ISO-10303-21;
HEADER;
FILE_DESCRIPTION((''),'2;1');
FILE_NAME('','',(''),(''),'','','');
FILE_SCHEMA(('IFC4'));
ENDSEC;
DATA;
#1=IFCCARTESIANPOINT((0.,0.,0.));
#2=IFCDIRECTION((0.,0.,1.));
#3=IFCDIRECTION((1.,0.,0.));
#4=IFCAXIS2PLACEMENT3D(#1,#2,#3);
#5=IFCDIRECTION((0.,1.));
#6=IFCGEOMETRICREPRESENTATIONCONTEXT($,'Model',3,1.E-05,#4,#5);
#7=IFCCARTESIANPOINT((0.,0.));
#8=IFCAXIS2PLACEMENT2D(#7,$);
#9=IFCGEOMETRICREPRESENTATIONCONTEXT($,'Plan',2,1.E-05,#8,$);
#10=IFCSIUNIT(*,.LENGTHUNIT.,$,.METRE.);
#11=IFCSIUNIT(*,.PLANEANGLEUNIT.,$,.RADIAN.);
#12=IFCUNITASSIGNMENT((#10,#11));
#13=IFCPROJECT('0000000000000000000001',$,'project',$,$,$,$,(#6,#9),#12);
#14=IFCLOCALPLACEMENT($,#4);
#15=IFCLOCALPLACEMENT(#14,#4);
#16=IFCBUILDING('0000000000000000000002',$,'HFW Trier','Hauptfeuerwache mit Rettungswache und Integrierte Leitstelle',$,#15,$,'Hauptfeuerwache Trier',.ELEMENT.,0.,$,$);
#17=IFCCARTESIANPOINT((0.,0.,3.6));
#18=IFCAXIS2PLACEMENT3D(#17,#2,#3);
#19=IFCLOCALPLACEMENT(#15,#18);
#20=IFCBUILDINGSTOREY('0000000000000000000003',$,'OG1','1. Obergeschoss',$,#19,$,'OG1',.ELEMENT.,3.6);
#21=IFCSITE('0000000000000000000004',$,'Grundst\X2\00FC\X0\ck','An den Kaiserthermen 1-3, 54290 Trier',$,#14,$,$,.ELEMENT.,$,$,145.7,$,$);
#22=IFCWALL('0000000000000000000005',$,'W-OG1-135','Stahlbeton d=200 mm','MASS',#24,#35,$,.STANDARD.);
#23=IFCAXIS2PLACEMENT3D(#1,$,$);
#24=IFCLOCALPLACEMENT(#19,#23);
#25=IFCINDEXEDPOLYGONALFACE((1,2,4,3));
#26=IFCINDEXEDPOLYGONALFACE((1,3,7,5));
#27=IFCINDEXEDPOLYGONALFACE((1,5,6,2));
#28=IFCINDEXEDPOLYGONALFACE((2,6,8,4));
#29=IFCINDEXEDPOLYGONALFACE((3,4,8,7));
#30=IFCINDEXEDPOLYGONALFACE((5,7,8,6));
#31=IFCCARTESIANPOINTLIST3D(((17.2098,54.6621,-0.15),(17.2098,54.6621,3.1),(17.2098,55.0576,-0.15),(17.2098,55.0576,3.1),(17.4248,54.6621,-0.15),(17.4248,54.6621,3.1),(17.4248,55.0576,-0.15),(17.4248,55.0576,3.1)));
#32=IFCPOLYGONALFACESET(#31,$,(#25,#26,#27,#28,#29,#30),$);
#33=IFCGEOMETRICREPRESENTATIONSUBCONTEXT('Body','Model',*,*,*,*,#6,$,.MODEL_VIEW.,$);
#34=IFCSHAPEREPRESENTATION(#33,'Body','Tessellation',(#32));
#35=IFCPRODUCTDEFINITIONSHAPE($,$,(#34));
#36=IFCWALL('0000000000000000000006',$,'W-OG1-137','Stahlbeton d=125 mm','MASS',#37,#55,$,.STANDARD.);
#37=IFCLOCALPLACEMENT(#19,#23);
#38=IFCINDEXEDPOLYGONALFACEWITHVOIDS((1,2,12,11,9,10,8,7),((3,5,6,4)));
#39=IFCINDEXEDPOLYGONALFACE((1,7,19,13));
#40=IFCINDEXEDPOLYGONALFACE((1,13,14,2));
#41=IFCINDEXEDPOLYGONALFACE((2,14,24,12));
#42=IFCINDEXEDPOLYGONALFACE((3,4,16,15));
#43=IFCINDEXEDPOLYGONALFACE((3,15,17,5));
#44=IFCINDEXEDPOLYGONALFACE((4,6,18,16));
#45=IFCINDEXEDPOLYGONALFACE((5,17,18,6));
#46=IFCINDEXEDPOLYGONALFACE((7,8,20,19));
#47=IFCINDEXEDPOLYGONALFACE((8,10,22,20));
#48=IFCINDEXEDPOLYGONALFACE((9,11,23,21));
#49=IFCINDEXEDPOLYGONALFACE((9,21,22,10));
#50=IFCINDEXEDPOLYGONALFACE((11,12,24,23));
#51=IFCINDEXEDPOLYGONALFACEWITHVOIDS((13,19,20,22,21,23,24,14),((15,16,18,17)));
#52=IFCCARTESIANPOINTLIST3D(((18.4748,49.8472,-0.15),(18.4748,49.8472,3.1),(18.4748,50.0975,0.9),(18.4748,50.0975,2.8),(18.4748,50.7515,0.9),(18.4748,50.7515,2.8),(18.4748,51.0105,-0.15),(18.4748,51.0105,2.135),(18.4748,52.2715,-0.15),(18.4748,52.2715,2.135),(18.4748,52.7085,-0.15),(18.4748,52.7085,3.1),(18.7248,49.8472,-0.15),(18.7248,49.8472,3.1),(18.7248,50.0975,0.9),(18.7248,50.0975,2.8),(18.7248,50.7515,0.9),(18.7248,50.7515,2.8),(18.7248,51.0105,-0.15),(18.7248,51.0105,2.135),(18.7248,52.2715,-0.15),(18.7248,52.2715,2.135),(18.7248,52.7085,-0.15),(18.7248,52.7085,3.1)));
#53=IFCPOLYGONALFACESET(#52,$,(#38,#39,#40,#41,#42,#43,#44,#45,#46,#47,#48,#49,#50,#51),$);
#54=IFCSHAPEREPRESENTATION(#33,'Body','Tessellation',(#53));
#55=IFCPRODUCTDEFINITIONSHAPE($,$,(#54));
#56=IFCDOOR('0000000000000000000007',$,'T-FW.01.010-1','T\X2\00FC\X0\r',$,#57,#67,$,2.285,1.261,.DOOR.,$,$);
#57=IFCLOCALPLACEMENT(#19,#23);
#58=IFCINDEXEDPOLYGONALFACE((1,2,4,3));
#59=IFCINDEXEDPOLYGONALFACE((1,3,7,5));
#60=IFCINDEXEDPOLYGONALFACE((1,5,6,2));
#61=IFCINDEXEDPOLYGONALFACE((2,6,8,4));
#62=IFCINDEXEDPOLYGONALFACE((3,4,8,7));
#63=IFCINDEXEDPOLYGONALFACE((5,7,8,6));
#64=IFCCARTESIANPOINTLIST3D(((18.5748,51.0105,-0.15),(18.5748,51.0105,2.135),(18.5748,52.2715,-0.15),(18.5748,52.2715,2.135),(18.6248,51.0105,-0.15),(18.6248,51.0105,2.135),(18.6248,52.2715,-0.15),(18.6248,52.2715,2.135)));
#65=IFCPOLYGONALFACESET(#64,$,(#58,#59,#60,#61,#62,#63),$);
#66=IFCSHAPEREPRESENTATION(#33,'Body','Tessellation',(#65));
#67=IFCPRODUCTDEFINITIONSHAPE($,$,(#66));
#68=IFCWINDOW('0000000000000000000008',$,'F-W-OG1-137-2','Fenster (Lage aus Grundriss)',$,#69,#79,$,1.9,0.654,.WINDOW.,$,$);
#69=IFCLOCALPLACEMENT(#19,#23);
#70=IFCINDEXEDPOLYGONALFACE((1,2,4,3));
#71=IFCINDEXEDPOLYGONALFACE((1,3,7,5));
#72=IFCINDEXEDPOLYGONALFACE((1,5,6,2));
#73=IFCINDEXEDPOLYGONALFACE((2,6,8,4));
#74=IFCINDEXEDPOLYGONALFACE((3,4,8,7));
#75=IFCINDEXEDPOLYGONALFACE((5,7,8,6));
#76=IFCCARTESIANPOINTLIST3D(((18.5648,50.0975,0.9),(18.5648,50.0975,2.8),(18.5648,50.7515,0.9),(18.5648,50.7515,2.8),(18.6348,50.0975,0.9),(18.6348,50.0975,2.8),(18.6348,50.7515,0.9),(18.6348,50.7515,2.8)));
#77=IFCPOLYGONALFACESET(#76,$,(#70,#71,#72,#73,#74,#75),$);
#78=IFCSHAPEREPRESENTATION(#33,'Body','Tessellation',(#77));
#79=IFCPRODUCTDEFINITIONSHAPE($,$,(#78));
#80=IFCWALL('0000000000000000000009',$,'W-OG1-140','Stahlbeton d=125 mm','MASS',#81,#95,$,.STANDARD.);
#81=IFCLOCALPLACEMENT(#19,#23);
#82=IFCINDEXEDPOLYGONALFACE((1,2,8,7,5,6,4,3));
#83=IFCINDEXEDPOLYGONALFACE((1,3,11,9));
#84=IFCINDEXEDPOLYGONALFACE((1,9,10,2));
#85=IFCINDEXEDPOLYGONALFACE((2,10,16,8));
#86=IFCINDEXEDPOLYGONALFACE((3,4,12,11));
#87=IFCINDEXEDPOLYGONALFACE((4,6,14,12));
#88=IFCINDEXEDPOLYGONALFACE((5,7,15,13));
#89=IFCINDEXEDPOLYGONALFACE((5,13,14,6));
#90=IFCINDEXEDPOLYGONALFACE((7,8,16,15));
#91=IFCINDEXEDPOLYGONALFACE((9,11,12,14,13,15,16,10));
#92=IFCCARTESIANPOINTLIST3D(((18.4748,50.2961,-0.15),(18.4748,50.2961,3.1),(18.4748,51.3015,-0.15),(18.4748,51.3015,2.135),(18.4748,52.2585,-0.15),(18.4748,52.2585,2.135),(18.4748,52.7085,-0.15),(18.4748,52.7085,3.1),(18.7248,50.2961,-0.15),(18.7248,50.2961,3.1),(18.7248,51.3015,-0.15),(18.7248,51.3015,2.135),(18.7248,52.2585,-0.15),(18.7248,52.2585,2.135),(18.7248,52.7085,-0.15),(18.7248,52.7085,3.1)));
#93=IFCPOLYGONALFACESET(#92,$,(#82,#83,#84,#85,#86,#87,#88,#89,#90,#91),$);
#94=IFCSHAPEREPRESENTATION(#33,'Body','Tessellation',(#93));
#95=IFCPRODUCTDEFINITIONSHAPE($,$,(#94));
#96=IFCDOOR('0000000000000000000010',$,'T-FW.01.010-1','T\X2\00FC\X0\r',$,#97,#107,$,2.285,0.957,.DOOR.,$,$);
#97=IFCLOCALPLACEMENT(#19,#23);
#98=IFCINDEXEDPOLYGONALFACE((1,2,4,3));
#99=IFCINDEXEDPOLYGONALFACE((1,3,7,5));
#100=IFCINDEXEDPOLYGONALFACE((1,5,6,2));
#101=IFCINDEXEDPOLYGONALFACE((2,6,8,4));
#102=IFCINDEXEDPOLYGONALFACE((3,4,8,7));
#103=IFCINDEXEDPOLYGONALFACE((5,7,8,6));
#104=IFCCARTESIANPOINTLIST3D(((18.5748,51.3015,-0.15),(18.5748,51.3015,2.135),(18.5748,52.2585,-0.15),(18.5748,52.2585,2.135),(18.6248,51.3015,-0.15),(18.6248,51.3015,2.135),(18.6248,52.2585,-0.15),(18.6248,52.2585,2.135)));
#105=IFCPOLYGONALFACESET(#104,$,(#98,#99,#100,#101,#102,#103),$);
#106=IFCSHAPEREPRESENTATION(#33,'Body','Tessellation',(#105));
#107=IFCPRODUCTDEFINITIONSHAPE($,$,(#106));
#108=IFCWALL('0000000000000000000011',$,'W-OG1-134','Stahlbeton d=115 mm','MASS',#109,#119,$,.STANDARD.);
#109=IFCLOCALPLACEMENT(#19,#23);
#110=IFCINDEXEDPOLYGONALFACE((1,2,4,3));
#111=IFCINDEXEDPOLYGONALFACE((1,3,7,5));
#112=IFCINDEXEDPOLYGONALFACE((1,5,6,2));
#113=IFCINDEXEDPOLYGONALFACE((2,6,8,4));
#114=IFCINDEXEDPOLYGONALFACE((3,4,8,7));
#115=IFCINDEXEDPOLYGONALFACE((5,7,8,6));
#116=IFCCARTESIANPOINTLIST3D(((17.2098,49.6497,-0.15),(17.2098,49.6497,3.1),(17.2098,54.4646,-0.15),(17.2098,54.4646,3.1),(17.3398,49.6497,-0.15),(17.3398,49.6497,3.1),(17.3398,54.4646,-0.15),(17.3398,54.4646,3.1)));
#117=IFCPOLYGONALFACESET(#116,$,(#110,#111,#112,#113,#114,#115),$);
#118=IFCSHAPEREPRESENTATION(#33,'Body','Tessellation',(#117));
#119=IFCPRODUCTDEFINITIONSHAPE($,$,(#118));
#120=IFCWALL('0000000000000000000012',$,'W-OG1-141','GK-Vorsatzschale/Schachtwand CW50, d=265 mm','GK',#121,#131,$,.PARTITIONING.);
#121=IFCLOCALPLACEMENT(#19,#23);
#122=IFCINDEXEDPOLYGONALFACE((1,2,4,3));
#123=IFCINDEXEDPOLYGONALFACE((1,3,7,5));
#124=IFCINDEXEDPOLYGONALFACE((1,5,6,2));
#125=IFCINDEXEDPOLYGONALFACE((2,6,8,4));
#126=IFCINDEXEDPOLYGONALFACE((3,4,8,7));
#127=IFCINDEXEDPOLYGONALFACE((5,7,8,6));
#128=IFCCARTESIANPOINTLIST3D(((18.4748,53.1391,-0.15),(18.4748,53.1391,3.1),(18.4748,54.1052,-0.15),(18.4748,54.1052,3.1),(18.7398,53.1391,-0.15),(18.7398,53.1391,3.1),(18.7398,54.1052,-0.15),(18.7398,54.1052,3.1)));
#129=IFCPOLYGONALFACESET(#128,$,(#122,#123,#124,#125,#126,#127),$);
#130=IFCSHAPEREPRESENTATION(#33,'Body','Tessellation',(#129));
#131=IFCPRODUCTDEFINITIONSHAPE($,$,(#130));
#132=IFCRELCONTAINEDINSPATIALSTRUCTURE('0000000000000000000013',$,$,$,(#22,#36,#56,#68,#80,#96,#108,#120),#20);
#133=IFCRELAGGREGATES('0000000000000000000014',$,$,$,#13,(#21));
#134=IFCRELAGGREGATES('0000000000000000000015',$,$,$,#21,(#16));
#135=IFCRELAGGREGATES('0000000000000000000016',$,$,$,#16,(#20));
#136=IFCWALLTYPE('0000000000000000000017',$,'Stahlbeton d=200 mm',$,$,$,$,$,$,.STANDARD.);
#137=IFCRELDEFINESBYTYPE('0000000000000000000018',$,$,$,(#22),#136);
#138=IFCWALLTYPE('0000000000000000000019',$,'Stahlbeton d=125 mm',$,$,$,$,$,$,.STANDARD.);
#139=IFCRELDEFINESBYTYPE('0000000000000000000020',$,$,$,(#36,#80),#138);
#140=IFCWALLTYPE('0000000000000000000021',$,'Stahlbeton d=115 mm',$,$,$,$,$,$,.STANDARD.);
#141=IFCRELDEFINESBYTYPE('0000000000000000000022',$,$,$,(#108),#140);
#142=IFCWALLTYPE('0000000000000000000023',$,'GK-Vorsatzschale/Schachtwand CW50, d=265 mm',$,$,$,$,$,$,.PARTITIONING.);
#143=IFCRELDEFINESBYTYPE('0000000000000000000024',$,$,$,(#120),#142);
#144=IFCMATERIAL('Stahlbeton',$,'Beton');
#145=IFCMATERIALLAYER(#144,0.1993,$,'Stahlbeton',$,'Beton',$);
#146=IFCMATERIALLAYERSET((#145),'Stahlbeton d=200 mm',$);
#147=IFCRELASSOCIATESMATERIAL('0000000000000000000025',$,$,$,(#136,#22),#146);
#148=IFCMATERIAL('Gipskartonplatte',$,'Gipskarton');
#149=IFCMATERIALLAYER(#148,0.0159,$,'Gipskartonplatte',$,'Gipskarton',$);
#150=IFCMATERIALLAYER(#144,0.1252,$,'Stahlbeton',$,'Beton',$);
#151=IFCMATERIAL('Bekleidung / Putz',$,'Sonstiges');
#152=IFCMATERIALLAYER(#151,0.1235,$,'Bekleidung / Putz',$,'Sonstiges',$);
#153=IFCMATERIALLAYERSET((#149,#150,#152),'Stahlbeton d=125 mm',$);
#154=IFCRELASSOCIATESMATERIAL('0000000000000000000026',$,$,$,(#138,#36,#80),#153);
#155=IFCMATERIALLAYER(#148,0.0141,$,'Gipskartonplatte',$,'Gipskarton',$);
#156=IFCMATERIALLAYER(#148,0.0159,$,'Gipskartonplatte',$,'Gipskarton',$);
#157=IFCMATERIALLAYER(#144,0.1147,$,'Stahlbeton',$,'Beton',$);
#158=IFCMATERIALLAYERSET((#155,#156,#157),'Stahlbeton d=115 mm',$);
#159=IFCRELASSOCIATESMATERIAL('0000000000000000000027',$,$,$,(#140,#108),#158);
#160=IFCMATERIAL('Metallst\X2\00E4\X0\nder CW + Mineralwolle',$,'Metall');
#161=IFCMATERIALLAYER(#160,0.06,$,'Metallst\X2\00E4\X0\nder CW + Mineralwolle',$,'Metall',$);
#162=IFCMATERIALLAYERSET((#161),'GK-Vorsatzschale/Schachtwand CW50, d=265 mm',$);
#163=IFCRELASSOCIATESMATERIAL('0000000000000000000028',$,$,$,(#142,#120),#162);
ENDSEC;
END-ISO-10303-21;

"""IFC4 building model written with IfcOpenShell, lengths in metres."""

from ifc_helpers import new_model, si_unit, direction, frame, frame_2d, origin_with_axes, origin_2d, place, context, subcontext, project, spatial, rectangle, extrude, material, layer, layer_set, layer_usage, type_object, element, fill, save


model = new_model("IFC4")

# Units and contexts
model_context = context("Model", 3, precision=1e-05, world=origin_with_axes(), true_north=direction((0.0, 1.0)))
plan_context = context("Plan", 2, precision=1e-05, world=origin_2d())
body_context = subcontext(model_context, "Body", "Model", "MODEL_VIEW")
ifc_project = project(units=[si_unit("LENGTHUNIT", "METRE"), si_unit("PLANEANGLEUNIT", "RADIAN")], contexts=[model_context, plan_context])

# Site, building, storey
site_placement = place(None, origin_with_axes())
site = spatial("IfcSite", under=ifc_project, at=site_placement, Name="Grundstück", Description="An den Kaiserthermen 1-3, 54290 Trier", CompositionType="ELEMENT", RefElevation=145.7)
building_placement = place(site_placement, origin_with_axes())
building = spatial("IfcBuilding", under=site, at=building_placement, Name="HFW Trier", Description="Hauptfeuerwache mit Rettungswache und Integrierte Leitstelle", LongName="Hauptfeuerwache Trier", CompositionType="ELEMENT", ElevationOfRefHeight=0.0)
storey_placement = place(building_placement, frame((0.0, 0.0, 3.6), z_axis=(0.0, 0.0, 1.0), x_axis=(1.0, 0.0, 0.0)))
storey = spatial("IfcBuildingStorey", under=building, at=storey_placement, Name="OG1", Description="1. Obergeschoss", LongName="OG1", CompositionType="ELEMENT", Elevation=3.6)

# Shared definitions
ifc_material_1 = material(Name="Gipskartonplatte", Category="Gipskarton")
ifc_material_2 = material(Name="Metallständer CW + Mineralwolle", Category="Metall")

# Wall
ifc_material_3 = material(Name="Stahlbeton", Category="Beton")
ifc_layer_1 = layer(ifc_material_3, 0.1993, Name="Stahlbeton", Category="Beton")
ifc_layer_set_1 = layer_set([ifc_layer_1], Name="Stahlbeton d=200 mm")
ifc_layer_usage_1 = layer_usage(ifc_layer_set_1, "AXIS2", "POSITIVE", -0.1075)
wall_type_1 = type_object("IfcWallType", Name="Stahlbeton d=200 mm", PredefinedType="STANDARD", material=ifc_layer_set_1)
wall_1_placement = place(storey_placement, frame((17.3173, 55.0576, -0.15), z_axis=(0.0, 0.0, 1.0), x_axis=(0.0, -1.0, 0.0)))
element("IfcWall", 1, at=wall_1_placement, inside=storey, type_object=wall_type_1, material=ifc_layer_usage_1, Name="W-OG1-135", Description="Stahlbeton d=200 mm", ObjectType="MASS", PredefinedType="STANDARD", context=body_context, shape_type="SweptSolid", body=[
    extrude(rectangle(XDim=0.3955, YDim=0.215, at=frame_2d((0.1977, 0.0))), origin_with_axes(), (0.0, 0.0, 1.0), 3.25),
])

# Wall, openings, door, window
ifc_layer_2 = layer(ifc_material_1, 0.0159, Name="Gipskartonplatte", Category="Gipskarton")
ifc_layer_3 = layer(ifc_material_3, 0.1252, Name="Stahlbeton", Category="Beton")
ifc_material_4 = material(Name="Bekleidung / Putz", Category="Sonstiges")
ifc_layer_4 = layer(ifc_material_4, 0.1235, Name="Bekleidung / Putz", Category="Sonstiges")
ifc_layer_set_2 = layer_set([ifc_layer_2, ifc_layer_3, ifc_layer_4], Name="Stahlbeton d=125 mm")
ifc_layer_usage_2 = layer_usage(ifc_layer_set_2, "AXIS2", "POSITIVE", -0.125)
wall_type_2 = type_object("IfcWallType", Name="Stahlbeton d=125 mm", PredefinedType="STANDARD", material=ifc_layer_set_2)
wall_2_placement = place(storey_placement, frame((18.5998, 52.7085, -0.15), z_axis=(0.0, 0.0, 1.0), x_axis=(0.0, -1.0, 0.0)))
wall_2 = element("IfcWall", 2, at=wall_2_placement, inside=storey, type_object=wall_type_2, material=ifc_layer_usage_2, Name="W-OG1-137", Description="Stahlbeton d=125 mm", ObjectType="MASS", PredefinedType="STANDARD", context=body_context, shape_type="SweptSolid", body=[
    extrude(rectangle(XDim=2.8613, YDim=0.25, at=frame_2d((1.4306, 0.0))), origin_with_axes(), (0.0, 0.0, 1.0), 3.25),
])
opening_1_placement = place(wall_2_placement, frame((0.437, 0.0, 0.0), z_axis=(0.0, 0.0, 1.0), x_axis=(1.0, 0.0, 0.0)))
opening_1 = element("IfcOpeningElement", 3, at=opening_1_placement, cuts=wall_2, PredefinedType="OPENING", context=body_context, shape_type="SweptSolid", body=[
    extrude(rectangle(XDim=1.261, YDim=0.35, at=frame_2d((0.6305, 0.0))), origin_with_axes(), (0.0, 0.0, 1.0), 2.285),
])
opening_2_placement = place(wall_2_placement, frame((1.957, 0.0, 0.0), z_axis=(0.0, 0.0, 1.0), x_axis=(1.0, 0.0, 0.0)))
opening_2 = element("IfcOpeningElement", 4, at=opening_2_placement, cuts=wall_2, PredefinedType="OPENING", context=body_context, shape_type="SweptSolid", body=[
    extrude(rectangle(XDim=0.654, YDim=0.35, at=frame_2d((0.327, 0.0))), frame((0.0, 0.0, 1.05), z_axis=(0.0, 0.0, 1.0), x_axis=(1.0, 0.0, 0.0)), (0.0, 0.0, 1.0), 1.9),
])
door_1_placement = place(wall_2_placement, frame((0.437, 0.0, 0.0), z_axis=(0.0, 0.0, 1.0), x_axis=(1.0, 0.0, 0.0)))
door_1 = element("IfcDoor", 5, at=door_1_placement, inside=storey, Name="T-FW.01.010-1", Description="Tür", OverallHeight=2.285, OverallWidth=1.261, PredefinedType="DOOR", context=body_context, shape_type="SweptSolid", body=[
    extrude(rectangle(XDim=1.261, YDim=0.05, at=frame_2d((0.6305, 0.0))), origin_with_axes(), (0.0, 0.0, 1.0), 2.285),
])
fill(opening_1, door_1)
window_placement = place(wall_2_placement, frame((1.957, 0.0, 0.0), z_axis=(0.0, 0.0, 1.0), x_axis=(1.0, 0.0, 0.0)))
window = element("IfcWindow", 6, at=window_placement, inside=storey, Name="F-W-OG1-137-2", Description="Fenster (Lage aus Grundriss)", OverallHeight=1.9, OverallWidth=0.654, PredefinedType="WINDOW", context=body_context, shape_type="SweptSolid", body=[
    extrude(rectangle(XDim=0.654, YDim=0.07, at=frame_2d((0.327, 0.0))), frame((0.0, 0.0, 1.05), z_axis=(0.0, 0.0, 1.0), x_axis=(1.0, 0.0, 0.0)), (0.0, 0.0, 1.0), 1.9),
])
fill(opening_2, window)

# Wall, opening, door
ifc_layer_usage_3 = layer_usage(ifc_layer_set_2, "AXIS2", "POSITIVE", -0.125)
wall_3_placement = place(storey_placement, frame((18.5998, 52.7085, -0.15), z_axis=(0.0, 0.0, 1.0), x_axis=(0.0, -1.0, 0.0)))
wall_3 = element("IfcWall", 7, at=wall_3_placement, inside=storey, type_object=wall_type_2, material=ifc_layer_usage_3, Name="W-OG1-140", Description="Stahlbeton d=125 mm", ObjectType="MASS", PredefinedType="STANDARD", context=body_context, shape_type="SweptSolid", body=[
    extrude(rectangle(XDim=2.4124, YDim=0.25, at=frame_2d((1.2062, 0.0))), origin_with_axes(), (0.0, 0.0, 1.0), 3.25),
])
opening_3_placement = place(wall_3_placement, frame((0.45, 0.0, 0.0), z_axis=(0.0, 0.0, 1.0), x_axis=(1.0, 0.0, 0.0)))
opening_3 = element("IfcOpeningElement", 8, at=opening_3_placement, cuts=wall_3, PredefinedType="OPENING", context=body_context, shape_type="SweptSolid", body=[
    extrude(rectangle(XDim=0.957, YDim=0.35, at=frame_2d((0.4785, 0.0))), origin_with_axes(), (0.0, 0.0, 1.0), 2.285),
])
door_2_placement = place(wall_3_placement, frame((0.45, 0.0, 0.0), z_axis=(0.0, 0.0, 1.0), x_axis=(1.0, 0.0, 0.0)))
door_2 = element("IfcDoor", 9, at=door_2_placement, inside=storey, Name="T-FW.01.010-1", Description="Tür", OverallHeight=2.285, OverallWidth=0.957, PredefinedType="DOOR", context=body_context, shape_type="SweptSolid", body=[
    extrude(rectangle(XDim=0.957, YDim=0.05, at=frame_2d((0.4785, 0.0))), origin_with_axes(), (0.0, 0.0, 1.0), 2.285),
])
fill(opening_3, door_2)

# Walls
ifc_layer_5 = layer(ifc_material_1, 0.0141, Name="Gipskartonplatte", Category="Gipskarton")
ifc_layer_6 = layer(ifc_material_1, 0.0159, Name="Gipskartonplatte", Category="Gipskarton")
ifc_layer_7 = layer(ifc_material_3, 0.1147, Name="Stahlbeton", Category="Beton")
ifc_layer_set_3 = layer_set([ifc_layer_5, ifc_layer_6, ifc_layer_7], Name="Stahlbeton d=115 mm")
ifc_layer_usage_4 = layer_usage(ifc_layer_set_3, "AXIS2", "POSITIVE", -0.065)
wall_type_3 = type_object("IfcWallType", Name="Stahlbeton d=115 mm", PredefinedType="STANDARD", material=ifc_layer_set_3)
wall_4_placement = place(storey_placement, frame((17.2748, 54.4646, -0.15), z_axis=(0.0, 0.0, 1.0), x_axis=(0.0, -1.0, 0.0)))
element("IfcWall", 10, at=wall_4_placement, inside=storey, type_object=wall_type_3, material=ifc_layer_usage_4, Name="W-OG1-134", Description="Stahlbeton d=115 mm", ObjectType="MASS", PredefinedType="STANDARD", context=body_context, shape_type="SweptSolid", body=[
    extrude(rectangle(XDim=4.8149, YDim=0.13, at=frame_2d((2.4074, 0.0))), origin_with_axes(), (0.0, 0.0, 1.0), 3.25),
])
ifc_layer_8 = layer(ifc_material_2, 0.06, Name="Metallständer CW + Mineralwolle", Category="Metall")
ifc_layer_set_4 = layer_set([ifc_layer_8], Name="GK-Vorsatzschale/Schachtwand CW50, d=265 mm")
ifc_layer_usage_5 = layer_usage(ifc_layer_set_4, "AXIS2", "POSITIVE", -0.1325)
wall_type_4 = type_object("IfcWallType", Name="GK-Vorsatzschale/Schachtwand CW50, d=265 mm", PredefinedType="PARTITIONING", material=ifc_layer_set_4)
wall_5_placement = place(storey_placement, frame((18.6073, 54.1052, -0.15), z_axis=(0.0, 0.0, 1.0), x_axis=(0.0, -1.0, 0.0)))
element("IfcWall", 11, at=wall_5_placement, inside=storey, type_object=wall_type_4, material=ifc_layer_usage_5, Name="W-OG1-141", Description="GK-Vorsatzschale/Schachtwand CW50, d=265 mm", ObjectType="GK", PredefinedType="PARTITIONING", context=body_context, shape_type="SweptSolid", body=[
    extrude(rectangle(XDim=0.9661, YDim=0.265, at=frame_2d((0.4831, 0.0))), origin_with_axes(), (0.0, 0.0, 1.0), 3.25),
])

save(model, "model.ifc")
